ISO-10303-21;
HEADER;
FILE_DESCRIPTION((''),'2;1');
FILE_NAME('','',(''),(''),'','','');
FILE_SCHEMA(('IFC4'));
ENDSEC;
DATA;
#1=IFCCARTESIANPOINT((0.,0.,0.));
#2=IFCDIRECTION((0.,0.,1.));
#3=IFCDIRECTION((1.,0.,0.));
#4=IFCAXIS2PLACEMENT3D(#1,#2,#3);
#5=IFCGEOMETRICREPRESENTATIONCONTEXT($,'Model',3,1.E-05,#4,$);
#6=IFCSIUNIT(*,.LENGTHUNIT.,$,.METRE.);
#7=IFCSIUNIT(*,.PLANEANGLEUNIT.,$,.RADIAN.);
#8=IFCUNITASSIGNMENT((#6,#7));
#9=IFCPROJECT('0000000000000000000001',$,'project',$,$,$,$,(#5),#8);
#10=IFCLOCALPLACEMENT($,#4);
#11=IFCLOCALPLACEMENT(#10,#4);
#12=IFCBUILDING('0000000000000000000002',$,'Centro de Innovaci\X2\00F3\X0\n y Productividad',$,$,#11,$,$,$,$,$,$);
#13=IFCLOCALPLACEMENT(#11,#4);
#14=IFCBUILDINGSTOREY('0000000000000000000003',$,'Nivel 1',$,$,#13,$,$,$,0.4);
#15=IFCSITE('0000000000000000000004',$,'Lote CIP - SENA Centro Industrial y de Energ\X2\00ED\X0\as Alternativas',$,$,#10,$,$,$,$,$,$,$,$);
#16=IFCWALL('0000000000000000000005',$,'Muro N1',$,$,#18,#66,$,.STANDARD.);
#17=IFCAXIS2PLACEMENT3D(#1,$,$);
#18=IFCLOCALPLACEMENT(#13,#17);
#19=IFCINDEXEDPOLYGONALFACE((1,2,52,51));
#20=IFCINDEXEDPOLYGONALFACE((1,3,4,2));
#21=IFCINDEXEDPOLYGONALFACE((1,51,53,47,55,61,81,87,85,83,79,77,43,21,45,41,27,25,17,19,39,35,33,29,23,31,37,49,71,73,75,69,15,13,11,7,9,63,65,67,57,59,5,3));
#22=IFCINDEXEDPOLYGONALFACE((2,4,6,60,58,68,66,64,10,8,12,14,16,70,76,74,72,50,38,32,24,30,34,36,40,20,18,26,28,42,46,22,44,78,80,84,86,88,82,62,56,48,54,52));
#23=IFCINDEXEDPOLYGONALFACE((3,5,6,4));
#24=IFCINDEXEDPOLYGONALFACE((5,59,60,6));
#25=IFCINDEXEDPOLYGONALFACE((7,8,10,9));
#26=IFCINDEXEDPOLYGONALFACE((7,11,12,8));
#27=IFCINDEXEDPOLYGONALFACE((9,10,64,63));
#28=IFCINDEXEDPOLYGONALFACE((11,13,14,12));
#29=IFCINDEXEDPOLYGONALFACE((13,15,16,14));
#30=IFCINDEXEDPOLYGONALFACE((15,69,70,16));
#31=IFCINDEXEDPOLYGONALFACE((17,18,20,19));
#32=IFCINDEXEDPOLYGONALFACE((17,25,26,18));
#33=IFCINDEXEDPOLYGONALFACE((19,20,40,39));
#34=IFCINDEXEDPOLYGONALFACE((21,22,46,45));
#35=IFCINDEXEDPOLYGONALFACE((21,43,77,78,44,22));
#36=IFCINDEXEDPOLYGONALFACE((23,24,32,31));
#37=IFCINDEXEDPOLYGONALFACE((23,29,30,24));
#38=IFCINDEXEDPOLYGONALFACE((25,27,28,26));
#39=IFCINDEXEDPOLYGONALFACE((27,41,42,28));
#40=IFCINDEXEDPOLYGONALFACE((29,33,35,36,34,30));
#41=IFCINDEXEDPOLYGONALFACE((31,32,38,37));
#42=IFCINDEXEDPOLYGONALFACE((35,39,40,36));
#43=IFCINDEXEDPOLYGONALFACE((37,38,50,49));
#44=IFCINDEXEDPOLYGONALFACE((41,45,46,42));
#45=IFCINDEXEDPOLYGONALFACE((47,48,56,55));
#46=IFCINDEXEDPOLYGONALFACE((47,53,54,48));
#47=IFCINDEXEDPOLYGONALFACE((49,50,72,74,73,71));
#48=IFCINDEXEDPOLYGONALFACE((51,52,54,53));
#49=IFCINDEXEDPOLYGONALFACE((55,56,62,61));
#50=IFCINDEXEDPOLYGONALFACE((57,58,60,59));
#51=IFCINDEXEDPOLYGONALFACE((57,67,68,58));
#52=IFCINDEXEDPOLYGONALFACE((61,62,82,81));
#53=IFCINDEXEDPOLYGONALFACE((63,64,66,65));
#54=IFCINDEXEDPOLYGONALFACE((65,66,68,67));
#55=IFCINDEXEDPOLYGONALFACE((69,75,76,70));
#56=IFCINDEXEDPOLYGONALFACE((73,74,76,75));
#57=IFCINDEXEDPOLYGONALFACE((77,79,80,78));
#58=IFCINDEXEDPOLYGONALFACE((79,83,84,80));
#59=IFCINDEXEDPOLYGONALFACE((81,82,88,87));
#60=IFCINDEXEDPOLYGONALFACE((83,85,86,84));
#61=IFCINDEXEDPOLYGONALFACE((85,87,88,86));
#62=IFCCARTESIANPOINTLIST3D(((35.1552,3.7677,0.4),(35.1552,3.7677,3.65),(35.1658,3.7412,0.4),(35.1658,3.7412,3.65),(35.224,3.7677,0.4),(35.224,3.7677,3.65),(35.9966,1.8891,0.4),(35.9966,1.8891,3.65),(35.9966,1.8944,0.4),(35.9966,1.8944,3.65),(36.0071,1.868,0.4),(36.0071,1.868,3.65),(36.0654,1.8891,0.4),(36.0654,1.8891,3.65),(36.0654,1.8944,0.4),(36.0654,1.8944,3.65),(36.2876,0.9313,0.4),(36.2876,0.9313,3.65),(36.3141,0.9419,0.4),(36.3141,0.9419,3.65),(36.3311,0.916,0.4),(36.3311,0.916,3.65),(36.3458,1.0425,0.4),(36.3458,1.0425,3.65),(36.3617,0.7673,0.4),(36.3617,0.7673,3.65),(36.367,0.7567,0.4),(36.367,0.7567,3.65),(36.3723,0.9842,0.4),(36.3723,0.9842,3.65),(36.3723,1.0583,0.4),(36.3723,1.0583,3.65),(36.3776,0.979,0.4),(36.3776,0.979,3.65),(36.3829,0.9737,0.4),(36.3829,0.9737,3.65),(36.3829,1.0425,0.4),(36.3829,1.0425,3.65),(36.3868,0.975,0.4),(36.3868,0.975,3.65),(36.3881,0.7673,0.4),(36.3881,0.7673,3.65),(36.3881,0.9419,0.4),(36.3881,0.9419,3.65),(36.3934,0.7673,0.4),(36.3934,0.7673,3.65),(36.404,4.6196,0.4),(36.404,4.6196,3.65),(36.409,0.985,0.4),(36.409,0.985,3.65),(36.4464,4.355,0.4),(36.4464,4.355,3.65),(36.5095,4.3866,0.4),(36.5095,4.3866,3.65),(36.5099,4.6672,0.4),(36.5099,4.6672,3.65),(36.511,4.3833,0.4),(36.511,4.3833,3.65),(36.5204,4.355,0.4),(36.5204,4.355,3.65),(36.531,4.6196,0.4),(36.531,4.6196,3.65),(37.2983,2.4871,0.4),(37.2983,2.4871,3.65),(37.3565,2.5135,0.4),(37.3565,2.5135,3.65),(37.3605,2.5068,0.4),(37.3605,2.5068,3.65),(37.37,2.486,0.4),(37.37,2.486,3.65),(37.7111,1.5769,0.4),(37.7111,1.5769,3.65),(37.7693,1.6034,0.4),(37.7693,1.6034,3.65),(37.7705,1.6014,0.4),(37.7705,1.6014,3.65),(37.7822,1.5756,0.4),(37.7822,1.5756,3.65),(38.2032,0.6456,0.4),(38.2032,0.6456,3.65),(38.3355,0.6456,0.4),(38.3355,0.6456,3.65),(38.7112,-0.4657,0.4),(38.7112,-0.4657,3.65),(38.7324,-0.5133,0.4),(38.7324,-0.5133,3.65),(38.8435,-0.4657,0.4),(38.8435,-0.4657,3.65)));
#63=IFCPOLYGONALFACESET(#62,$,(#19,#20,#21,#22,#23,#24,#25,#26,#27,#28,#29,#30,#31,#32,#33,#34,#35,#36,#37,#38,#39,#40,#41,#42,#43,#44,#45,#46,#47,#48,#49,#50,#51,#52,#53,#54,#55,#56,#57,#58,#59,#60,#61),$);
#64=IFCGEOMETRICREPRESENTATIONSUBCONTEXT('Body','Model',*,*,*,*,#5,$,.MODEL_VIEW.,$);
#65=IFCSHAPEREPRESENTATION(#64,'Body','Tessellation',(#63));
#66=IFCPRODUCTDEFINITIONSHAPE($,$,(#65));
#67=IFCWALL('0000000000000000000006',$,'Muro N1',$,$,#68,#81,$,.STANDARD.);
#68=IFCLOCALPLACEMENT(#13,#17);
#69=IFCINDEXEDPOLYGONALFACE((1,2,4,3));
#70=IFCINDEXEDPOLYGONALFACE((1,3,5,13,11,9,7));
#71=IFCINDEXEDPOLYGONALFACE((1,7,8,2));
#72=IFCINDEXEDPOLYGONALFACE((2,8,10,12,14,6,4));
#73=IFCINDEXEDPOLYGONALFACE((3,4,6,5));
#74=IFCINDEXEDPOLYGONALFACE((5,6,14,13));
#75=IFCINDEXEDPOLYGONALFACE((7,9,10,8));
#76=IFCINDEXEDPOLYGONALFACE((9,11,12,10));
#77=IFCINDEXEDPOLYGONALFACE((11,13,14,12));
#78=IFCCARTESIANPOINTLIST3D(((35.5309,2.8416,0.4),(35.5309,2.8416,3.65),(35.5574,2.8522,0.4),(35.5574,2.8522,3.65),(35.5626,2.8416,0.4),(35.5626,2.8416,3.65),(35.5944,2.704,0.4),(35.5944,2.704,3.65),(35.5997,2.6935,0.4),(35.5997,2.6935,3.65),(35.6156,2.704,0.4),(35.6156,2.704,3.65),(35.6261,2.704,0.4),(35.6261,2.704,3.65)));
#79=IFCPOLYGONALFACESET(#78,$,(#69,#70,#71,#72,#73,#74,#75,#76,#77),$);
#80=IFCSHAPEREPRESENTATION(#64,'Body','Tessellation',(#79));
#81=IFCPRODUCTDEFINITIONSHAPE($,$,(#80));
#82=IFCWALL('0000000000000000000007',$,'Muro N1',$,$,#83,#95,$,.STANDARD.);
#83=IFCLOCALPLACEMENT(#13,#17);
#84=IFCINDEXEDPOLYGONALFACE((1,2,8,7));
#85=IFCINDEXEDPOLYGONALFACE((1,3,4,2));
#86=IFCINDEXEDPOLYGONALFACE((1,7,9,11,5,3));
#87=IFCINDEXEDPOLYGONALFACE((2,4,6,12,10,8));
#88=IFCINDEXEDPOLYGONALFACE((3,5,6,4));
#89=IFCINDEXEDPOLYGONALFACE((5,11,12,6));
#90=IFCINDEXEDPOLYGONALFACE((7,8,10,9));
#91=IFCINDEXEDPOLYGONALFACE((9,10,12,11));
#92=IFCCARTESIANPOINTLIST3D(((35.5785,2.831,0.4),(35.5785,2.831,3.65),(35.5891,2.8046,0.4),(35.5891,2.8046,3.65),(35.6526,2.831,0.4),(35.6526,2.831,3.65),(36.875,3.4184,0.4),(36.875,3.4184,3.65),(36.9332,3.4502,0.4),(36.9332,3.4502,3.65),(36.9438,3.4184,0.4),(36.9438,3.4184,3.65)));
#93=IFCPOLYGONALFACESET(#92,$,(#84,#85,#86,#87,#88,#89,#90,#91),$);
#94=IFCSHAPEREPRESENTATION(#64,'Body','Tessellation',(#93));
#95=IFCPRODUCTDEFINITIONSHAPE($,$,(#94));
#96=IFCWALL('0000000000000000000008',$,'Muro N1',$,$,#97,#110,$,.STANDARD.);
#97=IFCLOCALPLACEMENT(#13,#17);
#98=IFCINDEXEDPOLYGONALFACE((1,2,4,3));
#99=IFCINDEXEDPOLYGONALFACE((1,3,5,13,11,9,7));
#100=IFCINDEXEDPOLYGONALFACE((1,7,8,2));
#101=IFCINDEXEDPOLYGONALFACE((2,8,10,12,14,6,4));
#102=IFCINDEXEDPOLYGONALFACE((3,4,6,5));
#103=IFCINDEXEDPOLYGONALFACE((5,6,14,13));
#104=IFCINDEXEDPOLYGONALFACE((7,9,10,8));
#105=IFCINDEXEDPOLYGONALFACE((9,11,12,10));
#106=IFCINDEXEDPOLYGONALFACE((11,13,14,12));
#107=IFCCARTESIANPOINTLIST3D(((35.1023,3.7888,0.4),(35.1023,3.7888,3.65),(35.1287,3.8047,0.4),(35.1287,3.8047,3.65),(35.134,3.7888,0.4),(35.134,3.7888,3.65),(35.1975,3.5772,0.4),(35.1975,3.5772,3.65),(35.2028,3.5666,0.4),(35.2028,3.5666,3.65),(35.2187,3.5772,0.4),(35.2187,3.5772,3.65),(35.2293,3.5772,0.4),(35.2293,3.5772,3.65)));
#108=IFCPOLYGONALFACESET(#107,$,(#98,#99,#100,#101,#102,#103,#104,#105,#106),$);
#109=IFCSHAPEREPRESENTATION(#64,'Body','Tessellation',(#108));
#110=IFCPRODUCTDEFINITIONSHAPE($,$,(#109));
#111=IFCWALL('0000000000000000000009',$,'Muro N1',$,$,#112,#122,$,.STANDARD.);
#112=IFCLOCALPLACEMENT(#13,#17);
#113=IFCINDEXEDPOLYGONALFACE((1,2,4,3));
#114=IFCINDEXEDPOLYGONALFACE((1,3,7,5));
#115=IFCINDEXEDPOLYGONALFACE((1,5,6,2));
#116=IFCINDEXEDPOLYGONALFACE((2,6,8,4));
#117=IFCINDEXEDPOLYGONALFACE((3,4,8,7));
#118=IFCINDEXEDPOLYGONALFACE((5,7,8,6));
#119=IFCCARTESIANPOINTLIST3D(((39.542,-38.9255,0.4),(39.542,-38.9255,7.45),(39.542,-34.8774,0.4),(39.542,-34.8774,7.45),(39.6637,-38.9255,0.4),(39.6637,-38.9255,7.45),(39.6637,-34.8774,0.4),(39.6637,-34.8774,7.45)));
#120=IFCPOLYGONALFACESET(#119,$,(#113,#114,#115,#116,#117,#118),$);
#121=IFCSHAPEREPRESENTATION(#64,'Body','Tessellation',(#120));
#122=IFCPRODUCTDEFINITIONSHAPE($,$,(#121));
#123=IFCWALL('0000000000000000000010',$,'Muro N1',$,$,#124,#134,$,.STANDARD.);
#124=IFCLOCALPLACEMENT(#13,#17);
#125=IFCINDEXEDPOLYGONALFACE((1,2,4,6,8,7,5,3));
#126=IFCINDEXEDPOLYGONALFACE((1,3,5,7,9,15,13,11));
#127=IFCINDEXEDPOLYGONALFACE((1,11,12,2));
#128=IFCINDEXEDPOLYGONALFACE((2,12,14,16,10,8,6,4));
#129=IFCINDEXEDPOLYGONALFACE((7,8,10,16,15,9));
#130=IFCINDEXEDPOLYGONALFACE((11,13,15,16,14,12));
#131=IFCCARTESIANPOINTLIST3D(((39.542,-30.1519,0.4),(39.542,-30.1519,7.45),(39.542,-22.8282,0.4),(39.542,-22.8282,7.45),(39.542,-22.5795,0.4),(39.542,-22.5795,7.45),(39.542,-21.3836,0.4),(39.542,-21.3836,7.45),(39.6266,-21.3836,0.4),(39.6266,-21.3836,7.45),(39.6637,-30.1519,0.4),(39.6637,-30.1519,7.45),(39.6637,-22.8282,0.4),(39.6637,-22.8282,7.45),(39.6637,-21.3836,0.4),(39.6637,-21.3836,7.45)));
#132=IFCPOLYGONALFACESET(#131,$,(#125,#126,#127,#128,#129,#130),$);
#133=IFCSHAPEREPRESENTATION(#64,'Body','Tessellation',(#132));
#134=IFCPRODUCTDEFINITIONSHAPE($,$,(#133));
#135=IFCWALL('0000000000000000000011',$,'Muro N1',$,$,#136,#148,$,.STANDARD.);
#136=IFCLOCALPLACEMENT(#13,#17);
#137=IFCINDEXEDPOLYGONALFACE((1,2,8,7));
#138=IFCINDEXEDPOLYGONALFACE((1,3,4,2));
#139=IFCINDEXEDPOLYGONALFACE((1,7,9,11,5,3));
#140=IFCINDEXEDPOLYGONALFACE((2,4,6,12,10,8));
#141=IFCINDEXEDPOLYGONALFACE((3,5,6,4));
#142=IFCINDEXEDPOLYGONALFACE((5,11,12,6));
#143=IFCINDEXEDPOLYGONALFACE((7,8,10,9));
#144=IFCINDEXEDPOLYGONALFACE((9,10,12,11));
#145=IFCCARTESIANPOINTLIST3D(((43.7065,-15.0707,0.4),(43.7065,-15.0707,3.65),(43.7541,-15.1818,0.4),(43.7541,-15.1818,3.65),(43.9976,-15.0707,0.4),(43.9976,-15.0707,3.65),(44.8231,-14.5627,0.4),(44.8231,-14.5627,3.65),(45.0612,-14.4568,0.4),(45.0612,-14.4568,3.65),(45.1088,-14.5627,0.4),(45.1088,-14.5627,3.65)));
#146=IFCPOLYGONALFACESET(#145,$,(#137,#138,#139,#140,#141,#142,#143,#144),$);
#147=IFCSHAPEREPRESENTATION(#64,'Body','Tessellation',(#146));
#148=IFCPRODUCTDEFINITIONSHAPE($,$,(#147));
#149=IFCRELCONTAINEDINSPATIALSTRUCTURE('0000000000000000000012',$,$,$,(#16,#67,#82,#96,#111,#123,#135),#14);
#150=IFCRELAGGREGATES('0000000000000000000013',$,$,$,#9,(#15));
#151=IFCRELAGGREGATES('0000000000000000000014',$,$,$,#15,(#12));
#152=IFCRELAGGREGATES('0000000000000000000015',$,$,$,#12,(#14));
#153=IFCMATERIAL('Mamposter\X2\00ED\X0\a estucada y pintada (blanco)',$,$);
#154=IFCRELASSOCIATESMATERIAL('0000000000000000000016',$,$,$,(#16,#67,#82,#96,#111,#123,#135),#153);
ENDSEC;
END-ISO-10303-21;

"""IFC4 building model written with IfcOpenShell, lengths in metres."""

from ifc_helpers import new_model, si_unit, frame, origin_with_axes, place, context, subcontext, project, spatial, polyline, outline, extrude, material, element, save


model = new_model("IFC4")

# Units and contexts
model_context = context("Model", 3, precision=1e-05, world=origin_with_axes())
body_context = subcontext(model_context, "Body", "Model", "MODEL_VIEW")
ifc_project = project(units=[si_unit("LENGTHUNIT", "METRE"), si_unit("PLANEANGLEUNIT", "RADIAN")], contexts=[model_context])

# Site, building, storey
site_placement = place(None, origin_with_axes())
site = spatial("IfcSite", under=ifc_project, at=site_placement, Name="Lote CIP - SENA Centro Industrial y de Energías Alternativas")
building_placement = place(site_placement, origin_with_axes())
building = spatial("IfcBuilding", under=site, at=building_placement, Name="Centro de Innovación y Productividad")
storey_placement = place(building_placement, origin_with_axes())
storey = spatial("IfcBuildingStorey", under=building, at=storey_placement, Name="Nivel 1", Elevation=0.4)

# Walls
ifc_material_1 = material(Name="Mampostería estucada y pintada (blanco)")
wall_1_placement = place(storey_placement, origin_with_axes())
element("IfcWall", 1, at=wall_1_placement, inside=storey, material=ifc_material_1, Name="Muro N1", PredefinedType="STANDARD", context=body_context, shape_type="SweptSolid", body=[
    extrude(outline(polyline([(37.3565, 2.5135), (37.3605, 2.5068), (36.511, 4.3833), (36.5204, 4.355), (35.224, 3.7677), (35.1658, 3.7412), (35.1552, 3.7677), (36.4464, 4.355), (36.5095, 4.3866), (36.404, 4.6196), (36.5099, 4.6672), (36.531, 4.6196), (38.3355, 0.6456), (38.8435, -0.4657), (38.7324, -0.5133), (38.7112, -0.4657), (38.2032, 0.6456), (37.7822, 1.5756), (36.3881, 0.9419), (36.3311, 0.916), (36.3934, 0.7673), (36.3881, 0.7673), (36.367, 0.7567), (36.3617, 0.7673), (36.2876, 0.9313), (36.3141, 0.9419), (36.3868, 0.975), (36.3829, 0.9737), (36.3776, 0.979), (36.3723, 0.9842), (36.3458, 1.0425), (36.3723, 1.0583), (36.3829, 1.0425), (36.409, 0.985), (37.7111, 1.5769), (37.7693, 1.6034), (37.7705, 1.6014), (37.37, 2.486), (36.0654, 1.8944), (36.0654, 1.8891), (36.0071, 1.868), (35.9966, 1.8891), (35.9966, 1.8944), (37.2983, 2.4871), (37.3565, 2.5135)])), frame((0.0, 0.0, 0.4)), (0.0, 0.0, 1.0), 3.25),
])
wall_2_placement = place(storey_placement, origin_with_axes())
element("IfcWall", 2, at=wall_2_placement, inside=storey, material=ifc_material_1, Name="Muro N1", PredefinedType="STANDARD", context=body_context, shape_type="SweptSolid", body=[
    extrude(outline(polyline([(35.5574, 2.8522), (35.5626, 2.8416), (35.6261, 2.704), (35.6156, 2.704), (35.5997, 2.6935), (35.5944, 2.704), (35.5309, 2.8416), (35.5574, 2.8522)])), frame((0.0, 0.0, 0.4)), (0.0, 0.0, 1.0), 3.25),
])
wall_3_placement = place(storey_placement, origin_with_axes())
element("IfcWall", 3, at=wall_3_placement, inside=storey, material=ifc_material_1, Name="Muro N1", PredefinedType="STANDARD", context=body_context, shape_type="SweptSolid", body=[
    extrude(outline(polyline([(36.9332, 3.4502), (36.9438, 3.4184), (35.6526, 2.831), (35.5891, 2.8046), (35.5785, 2.831), (36.875, 3.4184), (36.9332, 3.4502)])), frame((0.0, 0.0, 0.4)), (0.0, 0.0, 1.0), 3.25),
])
wall_4_placement = place(storey_placement, origin_with_axes())
element("IfcWall", 4, at=wall_4_placement, inside=storey, material=ifc_material_1, Name="Muro N1", PredefinedType="STANDARD", context=body_context, shape_type="SweptSolid", body=[
    extrude(outline(polyline([(35.1975, 3.5772), (35.1023, 3.7888), (35.1287, 3.8047), (35.134, 3.7888), (35.2293, 3.5772), (35.2187, 3.5772), (35.2028, 3.5666), (35.1975, 3.5772)])), frame((0.0, 0.0, 0.4)), (0.0, 0.0, 1.0), 3.25),
])
wall_5_placement = place(storey_placement, origin_with_axes())
element("IfcWall", 5, at=wall_5_placement, inside=storey, material=ifc_material_1, Name="Muro N1", PredefinedType="STANDARD", context=body_context, shape_type="SweptSolid", body=[
    extrude(outline(polyline([(39.542, -38.9255), (39.542, -34.8774), (39.6637, -34.8774), (39.6637, -38.9255), (39.542, -38.9255)])), frame((0.0, 0.0, 0.4)), (0.0, 0.0, 1.0), 7.05),
])
wall_6_placement = place(storey_placement, origin_with_axes())
element("IfcWall", 6, at=wall_6_placement, inside=storey, material=ifc_material_1, Name="Muro N1", PredefinedType="STANDARD", context=body_context, shape_type="SweptSolid", body=[
    extrude(outline(polyline([(39.6266, -21.3836), (39.6637, -21.3836), (39.6637, -22.8283), (39.6637, -30.1519), (39.542, -30.1519), (39.542, -22.8283), (39.542, -22.5795), (39.542, -21.3836), (39.6266, -21.3836)])), frame((0.0, 0.0, 0.4)), (0.0, 0.0, 1.0), 7.05),
])
wall_7_placement = place(storey_placement, origin_with_axes())
element("IfcWall", 7, at=wall_7_placement, inside=storey, material=ifc_material_1, Name="Muro N1", PredefinedType="STANDARD", context=body_context, shape_type="SweptSolid", body=[
    extrude(outline(polyline([(45.0612, -14.4568), (45.1088, -14.5627), (43.9976, -15.0707), (43.7541, -15.1818), (43.7065, -15.0707), (44.8231, -14.5627), (45.0612, -14.4568)])), frame((0.0, 0.0, 0.4)), (0.0, 0.0, 1.0), 3.25),
])

save(model, "model.ifc")
